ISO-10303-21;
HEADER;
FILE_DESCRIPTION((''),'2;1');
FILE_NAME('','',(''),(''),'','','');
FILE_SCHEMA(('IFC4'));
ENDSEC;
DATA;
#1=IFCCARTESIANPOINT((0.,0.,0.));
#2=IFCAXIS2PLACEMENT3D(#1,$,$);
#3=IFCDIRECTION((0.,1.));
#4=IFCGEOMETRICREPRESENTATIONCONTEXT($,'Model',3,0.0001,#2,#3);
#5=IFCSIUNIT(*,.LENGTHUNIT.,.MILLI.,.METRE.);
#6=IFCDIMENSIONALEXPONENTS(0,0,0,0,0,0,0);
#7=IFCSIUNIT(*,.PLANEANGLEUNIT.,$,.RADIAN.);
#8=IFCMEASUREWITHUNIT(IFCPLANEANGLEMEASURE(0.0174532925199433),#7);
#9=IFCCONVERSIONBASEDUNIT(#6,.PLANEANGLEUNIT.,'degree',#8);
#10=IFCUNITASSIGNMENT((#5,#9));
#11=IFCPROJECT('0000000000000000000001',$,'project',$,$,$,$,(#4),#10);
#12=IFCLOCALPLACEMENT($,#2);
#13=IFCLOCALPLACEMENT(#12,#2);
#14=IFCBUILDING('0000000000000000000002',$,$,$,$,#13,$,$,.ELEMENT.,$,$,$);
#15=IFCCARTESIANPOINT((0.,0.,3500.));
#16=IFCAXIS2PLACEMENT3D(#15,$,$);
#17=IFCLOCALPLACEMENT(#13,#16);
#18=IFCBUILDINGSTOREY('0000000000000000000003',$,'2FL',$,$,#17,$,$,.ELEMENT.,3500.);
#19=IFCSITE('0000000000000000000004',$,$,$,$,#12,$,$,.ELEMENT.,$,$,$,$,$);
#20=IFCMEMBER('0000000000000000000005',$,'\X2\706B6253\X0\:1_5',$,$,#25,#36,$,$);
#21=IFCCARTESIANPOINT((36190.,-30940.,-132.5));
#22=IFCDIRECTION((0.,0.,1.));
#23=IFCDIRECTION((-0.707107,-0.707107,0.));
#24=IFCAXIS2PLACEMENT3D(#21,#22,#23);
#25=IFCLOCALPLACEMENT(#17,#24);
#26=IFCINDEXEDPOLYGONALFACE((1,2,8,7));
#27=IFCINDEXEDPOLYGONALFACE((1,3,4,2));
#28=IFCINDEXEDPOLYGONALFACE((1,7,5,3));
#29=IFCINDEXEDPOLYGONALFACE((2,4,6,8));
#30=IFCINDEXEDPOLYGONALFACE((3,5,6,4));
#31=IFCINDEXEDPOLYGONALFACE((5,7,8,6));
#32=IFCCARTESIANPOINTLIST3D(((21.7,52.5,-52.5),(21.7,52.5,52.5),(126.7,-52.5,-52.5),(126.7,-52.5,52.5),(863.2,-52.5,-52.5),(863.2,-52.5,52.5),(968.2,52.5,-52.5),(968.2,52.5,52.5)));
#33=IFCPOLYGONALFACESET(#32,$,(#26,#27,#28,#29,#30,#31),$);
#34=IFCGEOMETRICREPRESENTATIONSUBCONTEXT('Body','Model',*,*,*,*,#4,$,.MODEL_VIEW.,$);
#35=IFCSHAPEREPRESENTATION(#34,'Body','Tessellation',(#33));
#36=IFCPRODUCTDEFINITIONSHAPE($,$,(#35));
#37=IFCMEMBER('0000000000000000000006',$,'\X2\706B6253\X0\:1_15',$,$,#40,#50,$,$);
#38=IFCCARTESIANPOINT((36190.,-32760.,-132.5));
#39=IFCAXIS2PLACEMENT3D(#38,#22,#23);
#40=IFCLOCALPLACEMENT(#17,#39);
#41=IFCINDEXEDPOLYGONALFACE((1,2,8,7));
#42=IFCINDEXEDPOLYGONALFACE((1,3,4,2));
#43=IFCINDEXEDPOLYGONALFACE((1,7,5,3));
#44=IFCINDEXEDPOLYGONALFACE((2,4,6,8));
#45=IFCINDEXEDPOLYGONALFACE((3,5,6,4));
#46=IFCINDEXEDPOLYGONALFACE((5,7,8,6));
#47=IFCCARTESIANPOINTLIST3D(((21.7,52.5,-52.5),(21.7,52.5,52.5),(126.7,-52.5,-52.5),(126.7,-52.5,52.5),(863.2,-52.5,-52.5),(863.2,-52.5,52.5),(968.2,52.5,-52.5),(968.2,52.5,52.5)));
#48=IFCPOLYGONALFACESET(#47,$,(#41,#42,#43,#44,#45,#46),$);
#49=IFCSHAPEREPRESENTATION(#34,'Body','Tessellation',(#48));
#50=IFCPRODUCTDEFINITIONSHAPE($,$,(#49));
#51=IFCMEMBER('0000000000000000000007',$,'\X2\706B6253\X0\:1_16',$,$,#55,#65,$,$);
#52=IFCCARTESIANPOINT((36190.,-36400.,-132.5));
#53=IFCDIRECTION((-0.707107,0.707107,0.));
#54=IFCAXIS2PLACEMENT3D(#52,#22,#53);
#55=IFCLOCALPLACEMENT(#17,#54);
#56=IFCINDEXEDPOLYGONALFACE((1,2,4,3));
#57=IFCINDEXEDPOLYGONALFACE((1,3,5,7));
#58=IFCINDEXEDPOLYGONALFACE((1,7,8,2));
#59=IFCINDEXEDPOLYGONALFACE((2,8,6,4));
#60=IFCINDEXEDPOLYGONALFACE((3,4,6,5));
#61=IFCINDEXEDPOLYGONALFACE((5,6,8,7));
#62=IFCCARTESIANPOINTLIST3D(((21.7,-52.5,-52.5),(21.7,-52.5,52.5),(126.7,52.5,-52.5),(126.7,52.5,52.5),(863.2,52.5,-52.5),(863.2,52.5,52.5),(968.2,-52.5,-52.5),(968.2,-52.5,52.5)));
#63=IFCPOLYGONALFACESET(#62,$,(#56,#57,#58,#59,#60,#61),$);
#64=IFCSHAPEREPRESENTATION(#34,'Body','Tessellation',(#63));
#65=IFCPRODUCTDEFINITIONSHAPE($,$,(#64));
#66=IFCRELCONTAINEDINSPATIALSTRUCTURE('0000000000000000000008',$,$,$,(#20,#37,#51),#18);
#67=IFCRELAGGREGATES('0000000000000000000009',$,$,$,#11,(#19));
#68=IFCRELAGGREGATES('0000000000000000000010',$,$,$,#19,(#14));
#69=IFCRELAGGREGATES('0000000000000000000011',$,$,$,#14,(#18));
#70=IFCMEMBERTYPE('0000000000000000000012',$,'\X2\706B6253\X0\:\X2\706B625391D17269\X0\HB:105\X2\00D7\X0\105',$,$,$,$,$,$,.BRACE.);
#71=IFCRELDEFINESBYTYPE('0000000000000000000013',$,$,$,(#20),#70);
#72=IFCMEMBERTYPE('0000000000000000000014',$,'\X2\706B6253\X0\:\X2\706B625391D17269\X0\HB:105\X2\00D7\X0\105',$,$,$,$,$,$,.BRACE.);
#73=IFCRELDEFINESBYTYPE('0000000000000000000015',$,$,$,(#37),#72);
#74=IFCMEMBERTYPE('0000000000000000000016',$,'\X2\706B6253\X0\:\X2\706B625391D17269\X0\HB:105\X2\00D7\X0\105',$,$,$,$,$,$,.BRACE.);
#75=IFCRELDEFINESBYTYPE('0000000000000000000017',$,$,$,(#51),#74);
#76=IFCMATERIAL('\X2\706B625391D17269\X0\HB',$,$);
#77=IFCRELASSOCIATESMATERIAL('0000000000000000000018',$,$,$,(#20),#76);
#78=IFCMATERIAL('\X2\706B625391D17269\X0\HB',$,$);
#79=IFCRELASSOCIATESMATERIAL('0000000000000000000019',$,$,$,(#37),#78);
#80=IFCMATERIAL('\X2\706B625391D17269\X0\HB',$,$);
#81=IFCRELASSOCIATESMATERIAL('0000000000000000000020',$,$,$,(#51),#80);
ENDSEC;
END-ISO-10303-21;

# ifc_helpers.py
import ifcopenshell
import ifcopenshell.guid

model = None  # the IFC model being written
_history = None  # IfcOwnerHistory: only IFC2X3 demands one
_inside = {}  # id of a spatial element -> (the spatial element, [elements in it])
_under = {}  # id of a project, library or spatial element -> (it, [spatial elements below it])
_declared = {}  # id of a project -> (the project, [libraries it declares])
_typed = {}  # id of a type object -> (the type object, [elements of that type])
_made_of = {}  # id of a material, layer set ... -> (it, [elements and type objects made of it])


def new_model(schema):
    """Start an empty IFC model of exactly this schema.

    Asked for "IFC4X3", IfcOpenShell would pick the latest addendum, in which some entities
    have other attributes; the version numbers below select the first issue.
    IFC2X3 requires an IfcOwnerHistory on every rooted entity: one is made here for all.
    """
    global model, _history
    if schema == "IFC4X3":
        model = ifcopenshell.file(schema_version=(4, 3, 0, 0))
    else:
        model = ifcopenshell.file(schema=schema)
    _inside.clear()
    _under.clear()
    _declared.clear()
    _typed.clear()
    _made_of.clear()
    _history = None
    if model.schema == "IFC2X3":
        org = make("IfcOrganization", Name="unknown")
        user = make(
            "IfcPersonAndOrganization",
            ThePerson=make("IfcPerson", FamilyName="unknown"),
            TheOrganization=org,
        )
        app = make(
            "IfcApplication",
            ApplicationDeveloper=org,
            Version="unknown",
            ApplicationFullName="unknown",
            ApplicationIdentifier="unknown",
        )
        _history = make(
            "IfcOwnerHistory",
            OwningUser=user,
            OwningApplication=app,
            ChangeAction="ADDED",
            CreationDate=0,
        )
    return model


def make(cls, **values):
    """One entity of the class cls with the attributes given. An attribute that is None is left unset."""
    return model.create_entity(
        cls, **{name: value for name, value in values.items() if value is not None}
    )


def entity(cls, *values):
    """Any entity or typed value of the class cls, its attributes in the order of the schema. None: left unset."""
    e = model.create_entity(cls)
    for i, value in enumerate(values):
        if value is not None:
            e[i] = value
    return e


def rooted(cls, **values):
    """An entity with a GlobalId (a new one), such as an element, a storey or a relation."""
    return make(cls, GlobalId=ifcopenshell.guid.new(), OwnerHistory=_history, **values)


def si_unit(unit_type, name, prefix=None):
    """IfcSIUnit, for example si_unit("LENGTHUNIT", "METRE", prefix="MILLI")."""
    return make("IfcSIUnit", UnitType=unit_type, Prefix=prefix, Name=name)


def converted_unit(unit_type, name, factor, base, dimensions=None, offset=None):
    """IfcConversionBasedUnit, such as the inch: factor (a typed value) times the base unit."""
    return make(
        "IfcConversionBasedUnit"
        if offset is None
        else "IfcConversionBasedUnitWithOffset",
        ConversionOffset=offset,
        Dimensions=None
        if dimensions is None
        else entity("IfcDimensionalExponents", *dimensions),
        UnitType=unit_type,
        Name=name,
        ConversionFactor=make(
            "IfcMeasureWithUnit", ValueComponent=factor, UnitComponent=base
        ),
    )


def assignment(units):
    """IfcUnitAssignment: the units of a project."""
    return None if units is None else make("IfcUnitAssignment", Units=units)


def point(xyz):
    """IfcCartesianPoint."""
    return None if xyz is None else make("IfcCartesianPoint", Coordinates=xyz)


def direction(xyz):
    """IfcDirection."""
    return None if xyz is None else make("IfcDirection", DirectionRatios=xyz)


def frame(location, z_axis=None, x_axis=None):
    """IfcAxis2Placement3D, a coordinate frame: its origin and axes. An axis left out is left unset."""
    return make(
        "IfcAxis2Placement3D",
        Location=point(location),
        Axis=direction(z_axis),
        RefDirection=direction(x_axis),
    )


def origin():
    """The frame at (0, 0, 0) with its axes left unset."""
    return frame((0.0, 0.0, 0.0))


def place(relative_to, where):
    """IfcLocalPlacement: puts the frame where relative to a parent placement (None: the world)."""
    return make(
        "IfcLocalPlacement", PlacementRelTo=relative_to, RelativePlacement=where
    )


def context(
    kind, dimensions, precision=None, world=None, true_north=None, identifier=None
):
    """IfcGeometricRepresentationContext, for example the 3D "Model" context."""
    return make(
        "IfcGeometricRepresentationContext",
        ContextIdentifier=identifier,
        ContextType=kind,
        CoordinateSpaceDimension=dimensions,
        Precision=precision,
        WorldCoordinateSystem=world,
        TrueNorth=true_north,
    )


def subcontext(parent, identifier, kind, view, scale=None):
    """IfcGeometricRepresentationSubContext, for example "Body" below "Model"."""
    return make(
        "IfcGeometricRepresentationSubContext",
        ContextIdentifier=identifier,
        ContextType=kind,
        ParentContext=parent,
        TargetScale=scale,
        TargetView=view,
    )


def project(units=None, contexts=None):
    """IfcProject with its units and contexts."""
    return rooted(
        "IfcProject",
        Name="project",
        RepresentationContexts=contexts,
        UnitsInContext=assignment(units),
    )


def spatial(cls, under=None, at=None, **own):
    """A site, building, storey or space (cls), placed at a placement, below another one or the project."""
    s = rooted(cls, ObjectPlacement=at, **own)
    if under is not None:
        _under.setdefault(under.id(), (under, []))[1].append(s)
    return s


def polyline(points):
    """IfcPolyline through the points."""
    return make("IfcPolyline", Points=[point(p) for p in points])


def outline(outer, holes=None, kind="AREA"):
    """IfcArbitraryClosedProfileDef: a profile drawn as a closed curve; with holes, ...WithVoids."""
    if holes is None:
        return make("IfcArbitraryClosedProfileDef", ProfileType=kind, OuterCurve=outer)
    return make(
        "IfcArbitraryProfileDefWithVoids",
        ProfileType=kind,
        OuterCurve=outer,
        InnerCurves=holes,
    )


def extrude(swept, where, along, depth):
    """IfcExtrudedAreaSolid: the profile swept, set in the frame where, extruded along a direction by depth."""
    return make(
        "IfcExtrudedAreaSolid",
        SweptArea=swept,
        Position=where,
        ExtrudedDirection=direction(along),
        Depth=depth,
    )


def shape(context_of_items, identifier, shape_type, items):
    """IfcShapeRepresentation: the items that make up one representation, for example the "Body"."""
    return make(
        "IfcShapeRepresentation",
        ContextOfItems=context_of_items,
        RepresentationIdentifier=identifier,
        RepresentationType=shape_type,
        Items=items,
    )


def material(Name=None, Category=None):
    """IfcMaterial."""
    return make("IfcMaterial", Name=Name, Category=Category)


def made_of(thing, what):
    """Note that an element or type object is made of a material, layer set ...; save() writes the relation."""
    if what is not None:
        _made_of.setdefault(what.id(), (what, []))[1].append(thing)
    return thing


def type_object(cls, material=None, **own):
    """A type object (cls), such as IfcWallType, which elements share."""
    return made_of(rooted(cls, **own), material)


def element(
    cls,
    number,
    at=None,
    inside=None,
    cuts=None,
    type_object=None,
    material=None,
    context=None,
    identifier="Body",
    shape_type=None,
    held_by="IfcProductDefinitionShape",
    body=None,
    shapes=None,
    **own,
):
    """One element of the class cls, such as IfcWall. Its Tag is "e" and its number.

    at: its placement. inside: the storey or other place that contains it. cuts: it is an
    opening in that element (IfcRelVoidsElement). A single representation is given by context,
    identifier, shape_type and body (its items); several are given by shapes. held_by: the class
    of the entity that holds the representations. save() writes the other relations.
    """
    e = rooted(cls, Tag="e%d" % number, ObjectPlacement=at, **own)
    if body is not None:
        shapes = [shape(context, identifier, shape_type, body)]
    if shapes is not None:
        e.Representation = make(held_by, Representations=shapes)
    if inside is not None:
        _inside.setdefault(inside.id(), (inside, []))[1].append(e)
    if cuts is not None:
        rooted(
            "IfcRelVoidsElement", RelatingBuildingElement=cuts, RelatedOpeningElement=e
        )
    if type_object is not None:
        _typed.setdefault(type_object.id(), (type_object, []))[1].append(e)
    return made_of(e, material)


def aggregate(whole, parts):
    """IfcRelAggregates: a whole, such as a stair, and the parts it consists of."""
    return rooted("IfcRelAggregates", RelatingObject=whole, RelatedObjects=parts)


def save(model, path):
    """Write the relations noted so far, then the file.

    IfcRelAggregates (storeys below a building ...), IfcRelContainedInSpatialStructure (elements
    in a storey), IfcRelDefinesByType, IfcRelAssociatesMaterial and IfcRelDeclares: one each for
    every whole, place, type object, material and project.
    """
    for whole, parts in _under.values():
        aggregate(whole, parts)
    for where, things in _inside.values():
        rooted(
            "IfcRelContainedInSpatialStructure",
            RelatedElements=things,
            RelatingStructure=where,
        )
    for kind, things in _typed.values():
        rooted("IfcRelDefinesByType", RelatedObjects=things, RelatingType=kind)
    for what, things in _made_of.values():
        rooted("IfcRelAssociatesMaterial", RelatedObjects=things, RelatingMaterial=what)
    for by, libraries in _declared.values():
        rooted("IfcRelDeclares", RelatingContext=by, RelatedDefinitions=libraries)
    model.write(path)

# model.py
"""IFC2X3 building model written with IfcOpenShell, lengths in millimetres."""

from ifc_helpers import new_model, entity, si_unit, converted_unit, direction, frame, origin, place, context, subcontext, project, spatial, polyline, outline, extrude, material, type_object, element, save


model = new_model("IFC2X3")

# Units and contexts
model_context = context("Model", 3, precision=0.0001, world=origin(), true_north=direction((0.0, 1.0)))
body_context = subcontext(model_context, "Body", "Model", "MODEL_VIEW")
ifc_project = project(units=[si_unit("LENGTHUNIT", "METRE", prefix="MILLI"), converted_unit("PLANEANGLEUNIT", "degree", entity("IfcPlaneAngleMeasure", 0.0174532925199433), si_unit("PLANEANGLEUNIT", "RADIAN"), dimensions=[0, 0, 0, 0, 0, 0, 0])], contexts=[model_context])

# Site, building, storey
site_placement = place(None, origin())
site = spatial("IfcSite", under=ifc_project, at=site_placement, CompositionType="ELEMENT")
building_placement = place(site_placement, origin())
building = spatial("IfcBuilding", under=site, at=building_placement, CompositionType="ELEMENT")
storey_placement = place(building_placement, frame((0.0, 0.0, 3500.0)))
storey = spatial("IfcBuildingStorey", under=building, at=storey_placement, Name="2FL", CompositionType="ELEMENT", Elevation=3500.0)

# Members
ifc_material_1 = material(Name="火打金物HB")
member_type_1 = type_object("IfcMemberType", Name="火打:火打金物HB:105×105", PredefinedType="BRACE")
member_1_placement = place(storey_placement, frame((36190.0, -30940.0, -132.5), z_axis=(0.0, 0.0, 1.0), x_axis=(-0.707107, -0.707107, 0.0)))
element("IfcMember", 1, at=member_1_placement, inside=storey, type_object=member_type_1, material=ifc_material_1, Name="火打:1_5", context=body_context, shape_type="SweptSolid", body=[
    extrude(outline(polyline([(126.7, -52.5, 0.0), (21.7, 52.5, 0.0), (968.2, 52.5, 0.0), (863.2, -52.5, 0.0), (126.7, -52.5, 0.0)])), frame((0.0, 0.0, -52.5), z_axis=(0.0, 0.0, 1.0), x_axis=(1.0, 0.0, 0.0)), (0.0, 0.0, 1.0), 105.0),
])
ifc_material_2 = material(Name="火打金物HB")
member_type_2 = type_object("IfcMemberType", Name="火打:火打金物HB:105×105", PredefinedType="BRACE")
member_2_placement = place(storey_placement, frame((36190.0, -32760.0, -132.5), z_axis=(0.0, 0.0, 1.0), x_axis=(-0.707107, -0.707107, 0.0)))
element("IfcMember", 2, at=member_2_placement, inside=storey, type_object=member_type_2, material=ifc_material_2, Name="火打:1_15", context=body_context, shape_type="SweptSolid", body=[
    extrude(outline(polyline([(126.7, -52.5, 0.0), (21.7, 52.5, 0.0), (968.2, 52.5, 0.0), (863.2, -52.5, 0.0), (126.7, -52.5, 0.0)])), frame((0.0, 0.0, -52.5), z_axis=(0.0, 0.0, 1.0), x_axis=(1.0, 0.0, 0.0)), (0.0, 0.0, 1.0), 105.0),
])
ifc_material_3 = material(Name="火打金物HB")
member_type_3 = type_object("IfcMemberType", Name="火打:火打金物HB:105×105", PredefinedType="BRACE")
member_3_placement = place(storey_placement, frame((36190.0, -36400.0, -132.5), z_axis=(0.0, 0.0, 1.0), x_axis=(-0.707107, 0.707107, 0.0)))
element("IfcMember", 3, at=member_3_placement, inside=storey, type_object=member_type_3, material=ifc_material_3, Name="火打:1_16", context=body_context, shape_type="SweptSolid", body=[
    extrude(outline(polyline([(21.7, -52.5, 0.0), (126.7, 52.5, 0.0), (863.2, 52.5, 0.0), (968.2, -52.5, 0.0), (21.7, -52.5, 0.0)])), frame((0.0, 0.0, -52.5), z_axis=(0.0, 0.0, 1.0), x_axis=(1.0, 0.0, 0.0)), (0.0, 0.0, 1.0), 105.0),
])

save(model, "model.ifc")
